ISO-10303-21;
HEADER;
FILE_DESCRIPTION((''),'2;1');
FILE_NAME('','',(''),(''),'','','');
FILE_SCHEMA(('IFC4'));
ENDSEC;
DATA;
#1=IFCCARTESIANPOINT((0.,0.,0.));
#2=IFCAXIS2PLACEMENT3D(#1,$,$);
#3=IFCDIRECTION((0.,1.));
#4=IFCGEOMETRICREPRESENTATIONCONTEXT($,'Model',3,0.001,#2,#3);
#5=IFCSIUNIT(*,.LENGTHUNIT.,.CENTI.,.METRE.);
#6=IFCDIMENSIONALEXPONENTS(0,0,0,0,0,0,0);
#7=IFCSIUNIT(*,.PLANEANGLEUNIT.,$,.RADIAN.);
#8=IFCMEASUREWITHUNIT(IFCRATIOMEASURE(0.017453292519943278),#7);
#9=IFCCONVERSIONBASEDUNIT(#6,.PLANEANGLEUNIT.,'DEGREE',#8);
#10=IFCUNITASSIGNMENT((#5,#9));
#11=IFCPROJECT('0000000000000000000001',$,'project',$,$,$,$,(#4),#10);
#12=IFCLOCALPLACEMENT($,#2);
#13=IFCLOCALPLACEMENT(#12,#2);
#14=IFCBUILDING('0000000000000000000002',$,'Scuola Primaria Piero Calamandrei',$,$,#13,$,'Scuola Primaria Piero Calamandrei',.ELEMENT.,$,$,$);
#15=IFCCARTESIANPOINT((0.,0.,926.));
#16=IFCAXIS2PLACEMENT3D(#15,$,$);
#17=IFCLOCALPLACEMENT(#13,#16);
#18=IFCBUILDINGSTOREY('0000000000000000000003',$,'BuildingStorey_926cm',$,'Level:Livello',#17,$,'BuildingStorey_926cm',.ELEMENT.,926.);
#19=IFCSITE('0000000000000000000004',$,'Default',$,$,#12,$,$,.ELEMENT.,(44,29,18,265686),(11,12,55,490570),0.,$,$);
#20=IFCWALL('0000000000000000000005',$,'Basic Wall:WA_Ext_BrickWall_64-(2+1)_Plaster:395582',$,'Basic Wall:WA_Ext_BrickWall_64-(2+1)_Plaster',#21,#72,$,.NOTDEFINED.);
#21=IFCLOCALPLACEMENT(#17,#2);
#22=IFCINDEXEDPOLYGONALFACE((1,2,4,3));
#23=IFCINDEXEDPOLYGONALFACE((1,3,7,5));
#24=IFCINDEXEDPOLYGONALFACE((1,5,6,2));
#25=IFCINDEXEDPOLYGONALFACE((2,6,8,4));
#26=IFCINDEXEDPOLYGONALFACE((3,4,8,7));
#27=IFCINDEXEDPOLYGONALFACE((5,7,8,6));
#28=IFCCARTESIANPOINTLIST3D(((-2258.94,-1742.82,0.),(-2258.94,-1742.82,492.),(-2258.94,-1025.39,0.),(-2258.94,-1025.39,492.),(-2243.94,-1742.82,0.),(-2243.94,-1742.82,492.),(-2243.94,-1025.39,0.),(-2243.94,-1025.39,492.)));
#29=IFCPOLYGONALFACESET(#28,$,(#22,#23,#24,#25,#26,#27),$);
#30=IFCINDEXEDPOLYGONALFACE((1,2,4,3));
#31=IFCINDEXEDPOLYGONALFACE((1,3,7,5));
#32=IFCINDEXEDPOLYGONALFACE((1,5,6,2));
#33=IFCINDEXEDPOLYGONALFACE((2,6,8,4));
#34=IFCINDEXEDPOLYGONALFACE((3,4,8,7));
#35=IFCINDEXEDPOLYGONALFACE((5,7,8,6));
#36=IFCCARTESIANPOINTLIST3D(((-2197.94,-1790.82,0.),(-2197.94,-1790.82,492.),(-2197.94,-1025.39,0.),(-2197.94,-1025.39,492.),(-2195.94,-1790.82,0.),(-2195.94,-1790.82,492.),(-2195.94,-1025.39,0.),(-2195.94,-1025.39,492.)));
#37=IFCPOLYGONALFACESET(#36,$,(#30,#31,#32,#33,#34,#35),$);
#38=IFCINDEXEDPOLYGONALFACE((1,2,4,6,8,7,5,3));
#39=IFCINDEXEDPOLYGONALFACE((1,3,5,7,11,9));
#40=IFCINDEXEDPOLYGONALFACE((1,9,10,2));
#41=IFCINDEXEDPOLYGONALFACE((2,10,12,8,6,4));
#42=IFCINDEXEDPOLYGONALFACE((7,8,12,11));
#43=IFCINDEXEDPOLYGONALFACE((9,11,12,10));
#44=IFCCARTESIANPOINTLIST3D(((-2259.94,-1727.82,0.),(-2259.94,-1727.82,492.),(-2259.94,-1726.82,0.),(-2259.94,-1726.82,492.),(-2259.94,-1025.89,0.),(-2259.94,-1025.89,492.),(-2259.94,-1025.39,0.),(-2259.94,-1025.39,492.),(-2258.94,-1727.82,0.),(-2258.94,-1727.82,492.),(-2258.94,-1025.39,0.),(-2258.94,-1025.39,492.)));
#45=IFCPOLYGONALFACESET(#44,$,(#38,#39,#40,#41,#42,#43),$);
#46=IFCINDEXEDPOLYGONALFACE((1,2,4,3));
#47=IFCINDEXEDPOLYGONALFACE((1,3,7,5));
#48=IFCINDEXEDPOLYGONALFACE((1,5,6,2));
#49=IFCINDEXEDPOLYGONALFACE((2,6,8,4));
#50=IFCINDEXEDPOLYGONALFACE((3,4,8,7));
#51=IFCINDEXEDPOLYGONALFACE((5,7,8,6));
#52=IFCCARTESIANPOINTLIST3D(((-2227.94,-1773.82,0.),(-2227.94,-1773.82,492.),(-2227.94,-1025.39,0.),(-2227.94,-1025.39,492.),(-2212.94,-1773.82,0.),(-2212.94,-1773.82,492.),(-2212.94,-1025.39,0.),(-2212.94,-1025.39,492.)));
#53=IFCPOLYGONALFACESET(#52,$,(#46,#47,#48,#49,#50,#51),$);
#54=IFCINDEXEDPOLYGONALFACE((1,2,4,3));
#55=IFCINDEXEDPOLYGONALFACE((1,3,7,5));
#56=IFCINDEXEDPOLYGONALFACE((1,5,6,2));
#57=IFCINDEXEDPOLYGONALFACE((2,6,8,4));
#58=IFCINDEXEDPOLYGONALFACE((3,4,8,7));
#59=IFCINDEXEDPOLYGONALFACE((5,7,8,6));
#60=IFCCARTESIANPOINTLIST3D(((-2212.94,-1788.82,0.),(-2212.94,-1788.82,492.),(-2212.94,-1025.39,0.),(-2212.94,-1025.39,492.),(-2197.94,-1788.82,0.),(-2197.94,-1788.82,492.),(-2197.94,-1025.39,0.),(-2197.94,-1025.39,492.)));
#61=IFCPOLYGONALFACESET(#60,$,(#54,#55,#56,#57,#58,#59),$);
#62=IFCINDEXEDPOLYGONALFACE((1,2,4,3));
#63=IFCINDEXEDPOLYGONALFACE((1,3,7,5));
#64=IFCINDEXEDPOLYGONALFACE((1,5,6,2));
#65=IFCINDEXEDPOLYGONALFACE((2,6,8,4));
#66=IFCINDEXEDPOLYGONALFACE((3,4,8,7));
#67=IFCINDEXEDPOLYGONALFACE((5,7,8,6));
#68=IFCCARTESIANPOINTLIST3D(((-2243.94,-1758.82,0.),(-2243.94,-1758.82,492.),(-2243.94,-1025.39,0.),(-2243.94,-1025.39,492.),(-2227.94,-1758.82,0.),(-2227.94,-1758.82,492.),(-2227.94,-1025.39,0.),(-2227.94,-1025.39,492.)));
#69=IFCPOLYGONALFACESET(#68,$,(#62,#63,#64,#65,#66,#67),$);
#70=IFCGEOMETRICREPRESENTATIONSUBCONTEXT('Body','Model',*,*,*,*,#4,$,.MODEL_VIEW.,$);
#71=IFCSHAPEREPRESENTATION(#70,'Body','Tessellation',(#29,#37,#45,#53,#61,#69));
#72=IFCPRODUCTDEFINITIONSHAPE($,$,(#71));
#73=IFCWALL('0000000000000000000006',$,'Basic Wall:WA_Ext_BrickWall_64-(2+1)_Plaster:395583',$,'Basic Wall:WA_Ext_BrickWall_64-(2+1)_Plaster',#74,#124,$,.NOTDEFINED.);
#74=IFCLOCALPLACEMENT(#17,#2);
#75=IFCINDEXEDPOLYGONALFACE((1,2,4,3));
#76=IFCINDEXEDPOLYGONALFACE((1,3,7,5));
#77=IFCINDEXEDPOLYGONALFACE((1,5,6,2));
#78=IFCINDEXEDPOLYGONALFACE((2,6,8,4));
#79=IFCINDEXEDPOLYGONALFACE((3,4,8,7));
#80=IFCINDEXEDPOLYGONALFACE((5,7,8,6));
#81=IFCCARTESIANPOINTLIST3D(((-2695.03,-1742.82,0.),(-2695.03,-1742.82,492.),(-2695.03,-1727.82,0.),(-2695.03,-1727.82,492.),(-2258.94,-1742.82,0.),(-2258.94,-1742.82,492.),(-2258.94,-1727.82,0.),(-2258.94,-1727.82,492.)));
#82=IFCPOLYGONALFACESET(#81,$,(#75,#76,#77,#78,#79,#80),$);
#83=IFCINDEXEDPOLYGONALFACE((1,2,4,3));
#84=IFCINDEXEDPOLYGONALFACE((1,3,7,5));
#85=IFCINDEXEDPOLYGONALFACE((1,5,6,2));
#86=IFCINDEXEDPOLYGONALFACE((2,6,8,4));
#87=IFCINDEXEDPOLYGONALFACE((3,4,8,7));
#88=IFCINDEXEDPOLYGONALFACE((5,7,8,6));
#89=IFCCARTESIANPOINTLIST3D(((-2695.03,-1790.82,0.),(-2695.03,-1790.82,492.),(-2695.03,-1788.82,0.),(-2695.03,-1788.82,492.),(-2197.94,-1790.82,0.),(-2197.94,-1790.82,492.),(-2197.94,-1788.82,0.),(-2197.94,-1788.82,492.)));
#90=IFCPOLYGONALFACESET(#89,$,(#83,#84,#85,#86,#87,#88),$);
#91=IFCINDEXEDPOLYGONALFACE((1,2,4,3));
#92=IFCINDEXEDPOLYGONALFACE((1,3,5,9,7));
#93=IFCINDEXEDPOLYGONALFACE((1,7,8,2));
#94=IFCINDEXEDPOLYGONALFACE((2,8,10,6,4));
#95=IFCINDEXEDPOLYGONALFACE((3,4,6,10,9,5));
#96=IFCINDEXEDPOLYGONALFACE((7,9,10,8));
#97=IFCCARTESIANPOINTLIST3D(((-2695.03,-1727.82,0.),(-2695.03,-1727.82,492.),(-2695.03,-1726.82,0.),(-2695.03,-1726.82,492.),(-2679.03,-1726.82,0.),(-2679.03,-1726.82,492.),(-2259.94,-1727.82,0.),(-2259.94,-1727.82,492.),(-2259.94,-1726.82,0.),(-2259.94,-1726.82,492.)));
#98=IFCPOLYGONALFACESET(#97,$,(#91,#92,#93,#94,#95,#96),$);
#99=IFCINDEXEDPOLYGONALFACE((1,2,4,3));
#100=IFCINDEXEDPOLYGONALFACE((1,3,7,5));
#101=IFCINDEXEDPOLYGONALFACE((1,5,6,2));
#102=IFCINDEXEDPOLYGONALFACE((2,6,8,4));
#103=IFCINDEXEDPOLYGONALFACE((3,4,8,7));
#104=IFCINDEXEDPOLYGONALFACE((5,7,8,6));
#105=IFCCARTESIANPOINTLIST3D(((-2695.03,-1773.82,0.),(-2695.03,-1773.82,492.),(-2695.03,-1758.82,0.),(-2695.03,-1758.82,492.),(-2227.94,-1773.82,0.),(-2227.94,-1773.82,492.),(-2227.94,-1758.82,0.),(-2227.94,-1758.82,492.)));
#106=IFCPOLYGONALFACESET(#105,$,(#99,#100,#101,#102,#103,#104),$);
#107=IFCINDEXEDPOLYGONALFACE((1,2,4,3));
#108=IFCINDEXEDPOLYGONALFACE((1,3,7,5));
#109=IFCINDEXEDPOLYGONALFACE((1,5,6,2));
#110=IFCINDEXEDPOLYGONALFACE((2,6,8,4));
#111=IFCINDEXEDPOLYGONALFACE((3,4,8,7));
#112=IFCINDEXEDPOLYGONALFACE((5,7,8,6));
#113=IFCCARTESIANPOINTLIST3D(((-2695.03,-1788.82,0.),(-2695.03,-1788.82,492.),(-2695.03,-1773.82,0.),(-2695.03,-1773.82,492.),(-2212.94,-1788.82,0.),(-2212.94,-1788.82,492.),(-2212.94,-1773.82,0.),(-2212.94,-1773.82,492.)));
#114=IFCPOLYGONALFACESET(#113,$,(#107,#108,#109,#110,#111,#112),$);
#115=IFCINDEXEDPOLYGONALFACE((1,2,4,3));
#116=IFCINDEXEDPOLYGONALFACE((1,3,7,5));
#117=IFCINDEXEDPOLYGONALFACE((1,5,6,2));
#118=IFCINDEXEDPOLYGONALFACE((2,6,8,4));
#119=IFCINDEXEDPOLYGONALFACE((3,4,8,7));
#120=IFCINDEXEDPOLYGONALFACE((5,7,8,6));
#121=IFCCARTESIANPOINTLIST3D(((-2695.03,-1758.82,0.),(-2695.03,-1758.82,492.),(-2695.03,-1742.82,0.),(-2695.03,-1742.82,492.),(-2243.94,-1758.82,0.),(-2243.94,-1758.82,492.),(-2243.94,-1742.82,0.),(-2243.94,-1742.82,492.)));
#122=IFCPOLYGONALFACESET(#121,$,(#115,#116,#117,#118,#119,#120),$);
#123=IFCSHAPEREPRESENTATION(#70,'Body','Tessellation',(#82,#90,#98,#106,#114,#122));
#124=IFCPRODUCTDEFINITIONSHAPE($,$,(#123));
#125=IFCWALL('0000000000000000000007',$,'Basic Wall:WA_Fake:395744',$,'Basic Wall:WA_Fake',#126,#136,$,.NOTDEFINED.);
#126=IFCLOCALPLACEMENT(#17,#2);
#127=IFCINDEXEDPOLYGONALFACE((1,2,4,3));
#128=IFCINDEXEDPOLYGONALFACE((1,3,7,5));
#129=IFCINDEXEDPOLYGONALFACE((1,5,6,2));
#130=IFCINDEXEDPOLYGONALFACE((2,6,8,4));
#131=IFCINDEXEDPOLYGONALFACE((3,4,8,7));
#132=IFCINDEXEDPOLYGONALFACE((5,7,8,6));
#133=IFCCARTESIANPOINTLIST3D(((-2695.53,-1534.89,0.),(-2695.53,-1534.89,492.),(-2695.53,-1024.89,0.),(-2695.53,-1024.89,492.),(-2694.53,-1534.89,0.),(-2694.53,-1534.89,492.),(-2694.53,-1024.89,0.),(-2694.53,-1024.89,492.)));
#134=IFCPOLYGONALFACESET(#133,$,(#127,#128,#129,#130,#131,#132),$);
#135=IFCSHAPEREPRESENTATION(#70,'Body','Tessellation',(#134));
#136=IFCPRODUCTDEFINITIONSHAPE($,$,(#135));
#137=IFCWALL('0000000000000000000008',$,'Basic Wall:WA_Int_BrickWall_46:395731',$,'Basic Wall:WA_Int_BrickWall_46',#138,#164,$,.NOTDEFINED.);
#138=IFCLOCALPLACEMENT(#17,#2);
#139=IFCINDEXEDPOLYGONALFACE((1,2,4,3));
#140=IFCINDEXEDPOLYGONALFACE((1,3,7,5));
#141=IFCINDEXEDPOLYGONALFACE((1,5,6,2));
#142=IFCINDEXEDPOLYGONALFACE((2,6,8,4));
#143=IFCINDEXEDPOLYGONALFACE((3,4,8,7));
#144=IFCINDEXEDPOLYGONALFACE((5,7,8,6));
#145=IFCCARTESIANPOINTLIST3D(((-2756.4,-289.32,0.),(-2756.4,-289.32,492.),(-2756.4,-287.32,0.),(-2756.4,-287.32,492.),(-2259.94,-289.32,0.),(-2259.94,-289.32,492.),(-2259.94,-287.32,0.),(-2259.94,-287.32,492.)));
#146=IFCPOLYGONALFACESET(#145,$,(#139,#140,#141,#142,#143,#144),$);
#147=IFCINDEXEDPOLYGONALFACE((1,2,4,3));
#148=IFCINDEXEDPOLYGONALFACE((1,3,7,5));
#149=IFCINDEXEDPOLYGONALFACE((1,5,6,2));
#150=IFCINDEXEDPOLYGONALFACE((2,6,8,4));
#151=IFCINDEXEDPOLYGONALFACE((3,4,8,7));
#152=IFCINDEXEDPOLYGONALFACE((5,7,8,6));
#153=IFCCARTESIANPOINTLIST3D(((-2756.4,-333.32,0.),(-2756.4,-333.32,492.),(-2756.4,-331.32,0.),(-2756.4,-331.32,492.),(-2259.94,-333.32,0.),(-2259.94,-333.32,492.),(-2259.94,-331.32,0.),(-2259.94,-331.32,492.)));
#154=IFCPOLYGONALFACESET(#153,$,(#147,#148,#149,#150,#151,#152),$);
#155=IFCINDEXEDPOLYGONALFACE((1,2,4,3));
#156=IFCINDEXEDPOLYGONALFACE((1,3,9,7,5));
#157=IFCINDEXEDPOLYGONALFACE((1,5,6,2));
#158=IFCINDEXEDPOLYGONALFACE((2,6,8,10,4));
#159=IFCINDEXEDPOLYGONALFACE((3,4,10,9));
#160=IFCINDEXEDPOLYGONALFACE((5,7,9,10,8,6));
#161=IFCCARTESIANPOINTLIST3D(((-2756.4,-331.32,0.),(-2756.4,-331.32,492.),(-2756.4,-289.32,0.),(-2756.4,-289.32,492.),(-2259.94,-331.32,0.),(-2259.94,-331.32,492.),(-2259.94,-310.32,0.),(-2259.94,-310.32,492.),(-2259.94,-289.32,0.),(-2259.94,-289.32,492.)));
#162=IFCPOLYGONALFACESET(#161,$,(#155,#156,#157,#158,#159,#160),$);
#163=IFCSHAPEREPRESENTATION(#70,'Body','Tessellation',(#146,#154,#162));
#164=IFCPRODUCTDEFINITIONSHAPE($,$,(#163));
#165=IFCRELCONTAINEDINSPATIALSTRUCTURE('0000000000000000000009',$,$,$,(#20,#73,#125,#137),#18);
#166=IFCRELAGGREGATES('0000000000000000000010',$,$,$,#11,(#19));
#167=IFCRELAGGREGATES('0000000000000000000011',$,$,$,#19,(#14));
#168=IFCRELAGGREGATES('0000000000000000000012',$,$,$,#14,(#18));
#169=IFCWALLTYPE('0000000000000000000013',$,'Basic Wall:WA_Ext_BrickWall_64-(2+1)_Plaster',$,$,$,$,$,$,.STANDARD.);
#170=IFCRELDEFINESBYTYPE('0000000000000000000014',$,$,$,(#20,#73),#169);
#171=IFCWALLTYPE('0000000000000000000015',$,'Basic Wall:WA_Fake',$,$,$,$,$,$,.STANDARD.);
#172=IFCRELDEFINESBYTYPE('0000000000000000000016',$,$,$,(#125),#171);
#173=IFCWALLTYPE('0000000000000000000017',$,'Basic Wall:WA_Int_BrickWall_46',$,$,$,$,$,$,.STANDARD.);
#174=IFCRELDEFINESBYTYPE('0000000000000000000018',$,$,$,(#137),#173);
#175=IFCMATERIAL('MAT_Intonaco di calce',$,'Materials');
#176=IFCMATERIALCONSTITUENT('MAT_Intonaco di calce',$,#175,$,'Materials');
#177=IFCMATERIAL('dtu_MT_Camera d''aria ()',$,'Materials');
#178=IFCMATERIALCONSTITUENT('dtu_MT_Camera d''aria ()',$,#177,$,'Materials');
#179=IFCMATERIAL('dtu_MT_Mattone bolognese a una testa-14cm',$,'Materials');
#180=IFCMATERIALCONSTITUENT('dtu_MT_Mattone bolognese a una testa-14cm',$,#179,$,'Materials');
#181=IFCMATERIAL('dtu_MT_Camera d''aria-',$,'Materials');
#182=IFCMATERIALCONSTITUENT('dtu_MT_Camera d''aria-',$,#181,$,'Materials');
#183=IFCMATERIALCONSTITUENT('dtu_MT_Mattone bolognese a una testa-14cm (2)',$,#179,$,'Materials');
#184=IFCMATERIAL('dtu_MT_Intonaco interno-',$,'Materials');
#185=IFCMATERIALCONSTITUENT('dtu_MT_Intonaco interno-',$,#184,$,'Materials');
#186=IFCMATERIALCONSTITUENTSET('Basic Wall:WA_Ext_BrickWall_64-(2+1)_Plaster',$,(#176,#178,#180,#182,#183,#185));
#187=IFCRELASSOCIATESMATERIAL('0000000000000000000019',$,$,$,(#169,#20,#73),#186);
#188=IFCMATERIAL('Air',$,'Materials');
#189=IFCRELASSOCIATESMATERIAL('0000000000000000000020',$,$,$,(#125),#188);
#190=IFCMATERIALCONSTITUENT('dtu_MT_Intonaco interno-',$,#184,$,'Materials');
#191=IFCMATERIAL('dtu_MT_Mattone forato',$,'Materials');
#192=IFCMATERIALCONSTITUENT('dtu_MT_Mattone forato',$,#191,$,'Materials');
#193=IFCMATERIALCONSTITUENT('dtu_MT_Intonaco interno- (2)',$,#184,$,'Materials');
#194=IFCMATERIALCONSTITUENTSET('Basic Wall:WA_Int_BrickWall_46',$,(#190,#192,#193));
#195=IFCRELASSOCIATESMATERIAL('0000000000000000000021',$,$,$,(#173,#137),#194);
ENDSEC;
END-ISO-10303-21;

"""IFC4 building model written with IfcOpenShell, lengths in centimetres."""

from ifc_helpers import new_model, entity, si_unit, converted_unit, direction, frame, origin, place, context, subcontext, project, spatial, indexed_curve, outline, extrude, material, constituent, constituent_set, type_object, element, save


model = new_model("IFC4")

# Units and contexts
model_context = context("Model", 3, precision=0.001, world=origin(), true_north=direction((0.0, 1.0)))
body_context = subcontext(model_context, "Body", "Model", "MODEL_VIEW")
ifc_project = project(units=[si_unit("LENGTHUNIT", "METRE", prefix="CENTI"), converted_unit("PLANEANGLEUNIT", "DEGREE", entity("IfcRatioMeasure", 0.017453292519943278), si_unit("PLANEANGLEUNIT", "RADIAN"), dimensions=[0, 0, 0, 0, 0, 0, 0])], contexts=[model_context])

# Site, building, storey
site_placement = place(None, origin())
site = spatial("IfcSite", under=ifc_project, at=site_placement, Name="Default", CompositionType="ELEMENT", RefLatitude=(44, 29, 18, 265686), RefLongitude=(11, 12, 55, 490570), RefElevation=0.0)
building_placement = place(site_placement, origin())
building = spatial("IfcBuilding", under=site, at=building_placement, Name="Scuola Primaria Piero Calamandrei", LongName="Scuola Primaria Piero Calamandrei", CompositionType="ELEMENT")
storey_placement = place(building_placement, frame((0.0, 0.0, 926.0)))
storey = spatial("IfcBuildingStorey", under=building, at=storey_placement, Name="BuildingStorey_926cm", ObjectType="Level:Livello", LongName="BuildingStorey_926cm", CompositionType="ELEMENT", Elevation=926.0)

# Walls
ifc_material_1 = material(Name="MAT_Intonaco di calce", Category="Materials")
ifc_constituent_1 = constituent(ifc_material_1, Name="MAT_Intonaco di calce", Category="Materials")
ifc_material_2 = material(Name="dtu_MT_Camera d'aria ()", Category="Materials")
ifc_constituent_2 = constituent(ifc_material_2, Name="dtu_MT_Camera d'aria ()", Category="Materials")
ifc_material_3 = material(Name="dtu_MT_Mattone bolognese a una testa-14cm", Category="Materials")
ifc_constituent_3 = constituent(ifc_material_3, Name="dtu_MT_Mattone bolognese a una testa-14cm", Category="Materials")
ifc_material_4 = material(Name="dtu_MT_Camera d'aria-", Category="Materials")
ifc_constituent_4 = constituent(ifc_material_4, Name="dtu_MT_Camera d'aria-", Category="Materials")
ifc_constituent_5 = constituent(ifc_material_3, Name="dtu_MT_Mattone bolognese a una testa-14cm (2)", Category="Materials")
ifc_material_5 = material(Name="dtu_MT_Intonaco interno-", Category="Materials")
ifc_constituent_6 = constituent(ifc_material_5, Name="dtu_MT_Intonaco interno-", Category="Materials")
ifc_constituent_set_1 = constituent_set(constituents=[ifc_constituent_1, ifc_constituent_2, ifc_constituent_3, ifc_constituent_4, ifc_constituent_5, ifc_constituent_6], Name="Basic Wall:WA_Ext_BrickWall_64-(2+1)_Plaster")
wall_type_1 = type_object("IfcWallType", Name="Basic Wall:WA_Ext_BrickWall_64-(2+1)_Plaster", PredefinedType="STANDARD", material=ifc_constituent_set_1)
wall_1_placement = place(storey_placement, frame((-2227.94, -1025.39, 0.0), z_axis=(0.0, 0.0, 1.0), x_axis=(0.0, -1.0, 0.0)))
element("IfcWall", 1, at=wall_1_placement, inside=storey, type_object=wall_type_1, material=ifc_constituent_set_1, Name="Basic Wall:WA_Ext_BrickWall_64-(2+1)_Plaster:395582", ObjectType="Basic Wall:WA_Ext_BrickWall_64-(2+1)_Plaster", PredefinedType="NOTDEFINED", context=body_context, shape_type="SweptSolid", body=[
    extrude(outline(indexed_curve([(-358.71, -7.5), (358.71, -7.5), (358.71, 7.5), (-358.71, 7.5), (-358.71, -7.5)], self_intersect=False)), frame((358.71, -23.5, 0.0)), (0.0, 0.0, 1.0), 492.0),
    extrude(outline(indexed_curve([(-1.0, -382.71), (1.0, -382.71), (1.0, 382.71), (-1.0, 382.71), (-1.0, -382.71)], self_intersect=False)), frame((382.71, 31.0, 0.0), z_axis=(0.0, 0.0, 1.0), x_axis=(0.0, -1.0, 0.0)), (0.0, 0.0, 1.0), 492.0),
    extrude(outline(indexed_curve([(-350.63, -0.33), (350.3, -0.33), (351.3, -0.33), (351.3, 0.67), (-351.13, 0.67), (-351.13, -0.33), (-350.63, -0.33)], self_intersect=False)), frame((351.13, -31.67, 0.0)), (0.0, 0.0, 1.0), 492.0),
    extrude(outline(indexed_curve([(-374.21, -7.5), (374.21, -7.5), (374.21, 7.5), (-374.21, 7.5), (-374.21, -7.5)], self_intersect=False)), frame((374.21, 7.5, 0.0)), (0.0, 0.0, 1.0), 492.0),
    extrude(outline(indexed_curve([(-381.71, -7.5), (381.71, -7.5), (381.71, 7.5), (-381.71, 7.5), (-381.71, -7.5)], self_intersect=False)), frame((381.71, 22.5, 0.0)), (0.0, 0.0, 1.0), 492.0),
    extrude(outline(indexed_curve([(-366.71, -8.0), (366.71, -8.0), (366.71, 8.0), (-366.71, 8.0), (-366.71, -8.0)], self_intersect=False)), frame((366.71, -8.0, 0.0)), (0.0, 0.0, 1.0), 492.0),
])
wall_2_placement = place(storey_placement, frame((-2259.94, -1758.82, 0.0), z_axis=(0.0, 0.0, 1.0), x_axis=(-1.0, 0.0, 0.0)))
element("IfcWall", 2, at=wall_2_placement, inside=storey, type_object=wall_type_1, material=ifc_constituent_set_1, Name="Basic Wall:WA_Ext_BrickWall_64-(2+1)_Plaster:395583", ObjectType="Basic Wall:WA_Ext_BrickWall_64-(2+1)_Plaster", PredefinedType="NOTDEFINED", context=body_context, shape_type="SweptSolid", body=[
    extrude(outline(indexed_curve([(-218.05, -7.5), (218.05, -7.5), (218.05, 7.5), (-218.05, 7.5), (-218.05, -7.5)], self_intersect=False)), frame((217.05, -23.5, 0.0)), (0.0, 0.0, 1.0), 492.0),
    extrude(outline(indexed_curve([(-1.0, -248.55), (1.0, -248.55), (1.0, 248.55), (-1.0, 248.55), (-1.0, -248.55)], self_intersect=False)), frame((186.55, 31.0, 0.0), z_axis=(0.0, 0.0, 1.0), x_axis=(0.0, -1.0, 0.0)), (0.0, 0.0, 1.0), 492.0),
    extrude(outline(indexed_curve([(161.24, -0.4), (177.24, -0.4), (177.24, 0.6), (-257.85, 0.6), (-257.85, -0.4), (161.24, -0.4)], self_intersect=False)), frame((257.85, -31.6, 0.0)), (0.0, 0.0, 1.0), 492.0),
    extrude(outline(indexed_curve([(-233.55, -7.5), (233.55, -7.5), (233.55, 7.5), (-233.55, 7.5), (-233.55, -7.5)], self_intersect=False)), frame((201.55, 7.5, 0.0)), (0.0, 0.0, 1.0), 492.0),
    extrude(outline(indexed_curve([(-241.05, -7.5), (241.05, -7.5), (241.05, 7.5), (-241.05, 7.5), (-241.05, -7.5)], self_intersect=False)), frame((194.05, 22.5, 0.0)), (0.0, 0.0, 1.0), 492.0),
    extrude(outline(indexed_curve([(-225.55, -8.0), (225.55, -8.0), (225.55, 8.0), (-225.55, 8.0), (-225.55, -8.0)], self_intersect=False)), frame((209.55, -8.0, 0.0)), (0.0, 0.0, 1.0), 492.0),
])
ifc_material_6 = material(Name="Air", Category="Materials")
wall_type_2 = type_object("IfcWallType", Name="Basic Wall:WA_Fake", PredefinedType="STANDARD")
wall_3_placement = place(storey_placement, frame((-2695.03, -1024.89, 0.0), z_axis=(0.0, 0.0, 1.0), x_axis=(0.0, -1.0, 0.0)))
element("IfcWall", 3, at=wall_3_placement, inside=storey, type_object=wall_type_2, material=ifc_material_6, Name="Basic Wall:WA_Fake:395744", ObjectType="Basic Wall:WA_Fake", PredefinedType="NOTDEFINED", context=body_context, shape_type="SweptSolid", body=[
    extrude(outline(indexed_curve([(510.0, 0.5), (0.0, 0.5), (0.0, -0.5), (510.0, -0.5), (510.0, 0.5)], self_intersect=False)), origin(), (0.0, 0.0, 1.0), 492.0),
])
ifc_constituent_7 = constituent(ifc_material_5, Name="dtu_MT_Intonaco interno-", Category="Materials")
ifc_material_7 = material(Name="dtu_MT_Mattone forato", Category="Materials")
ifc_constituent_8 = constituent(ifc_material_7, Name="dtu_MT_Mattone forato", Category="Materials")
ifc_constituent_9 = constituent(ifc_material_5, Name="dtu_MT_Intonaco interno- (2)", Category="Materials")
ifc_constituent_set_2 = constituent_set(constituents=[ifc_constituent_7, ifc_constituent_8, ifc_constituent_9], Name="Basic Wall:WA_Int_BrickWall_46")
wall_type_3 = type_object("IfcWallType", Name="Basic Wall:WA_Int_BrickWall_46", PredefinedType="STANDARD", material=ifc_constituent_set_2)
wall_4_placement = place(storey_placement, frame((-2259.94, -310.32, 0.0), z_axis=(0.0, 0.0, 1.0), x_axis=(-1.0, 0.0, 0.0)))
element("IfcWall", 4, at=wall_4_placement, inside=storey, type_object=wall_type_3, material=ifc_constituent_set_2, Name="Basic Wall:WA_Int_BrickWall_46:395731", ObjectType="Basic Wall:WA_Int_BrickWall_46", PredefinedType="NOTDEFINED", context=body_context, shape_type="SweptSolid", body=[
    extrude(outline(indexed_curve([(-1.0, -248.23), (1.0, -248.23), (1.0, 248.23), (-1.0, 248.23), (-1.0, -248.23)], self_intersect=False)), frame((248.23, -22.0, 0.0), z_axis=(0.0, 0.0, 1.0), x_axis=(0.0, 1.0, 0.0)), (0.0, 0.0, 1.0), 492.0),
    extrude(outline(indexed_curve([(-1.0, -248.23), (1.0, -248.23), (1.0, 248.23), (-1.0, 248.23), (-1.0, -248.23)], self_intersect=False)), frame((248.23, 22.0, 0.0), z_axis=(0.0, 0.0, 1.0), x_axis=(0.0, -1.0, 0.0)), (0.0, 0.0, 1.0), 492.0),
    extrude(outline(indexed_curve([(-198.59, -21.0), (297.88, -21.0), (297.88, 21.0), (-198.59, 21.0), (-198.59, 0.0), (-198.59, -21.0)], self_intersect=False)), frame((198.59, 0.0, 0.0)), (0.0, 0.0, 1.0), 492.0),
])

save(model, "model.ifc")
